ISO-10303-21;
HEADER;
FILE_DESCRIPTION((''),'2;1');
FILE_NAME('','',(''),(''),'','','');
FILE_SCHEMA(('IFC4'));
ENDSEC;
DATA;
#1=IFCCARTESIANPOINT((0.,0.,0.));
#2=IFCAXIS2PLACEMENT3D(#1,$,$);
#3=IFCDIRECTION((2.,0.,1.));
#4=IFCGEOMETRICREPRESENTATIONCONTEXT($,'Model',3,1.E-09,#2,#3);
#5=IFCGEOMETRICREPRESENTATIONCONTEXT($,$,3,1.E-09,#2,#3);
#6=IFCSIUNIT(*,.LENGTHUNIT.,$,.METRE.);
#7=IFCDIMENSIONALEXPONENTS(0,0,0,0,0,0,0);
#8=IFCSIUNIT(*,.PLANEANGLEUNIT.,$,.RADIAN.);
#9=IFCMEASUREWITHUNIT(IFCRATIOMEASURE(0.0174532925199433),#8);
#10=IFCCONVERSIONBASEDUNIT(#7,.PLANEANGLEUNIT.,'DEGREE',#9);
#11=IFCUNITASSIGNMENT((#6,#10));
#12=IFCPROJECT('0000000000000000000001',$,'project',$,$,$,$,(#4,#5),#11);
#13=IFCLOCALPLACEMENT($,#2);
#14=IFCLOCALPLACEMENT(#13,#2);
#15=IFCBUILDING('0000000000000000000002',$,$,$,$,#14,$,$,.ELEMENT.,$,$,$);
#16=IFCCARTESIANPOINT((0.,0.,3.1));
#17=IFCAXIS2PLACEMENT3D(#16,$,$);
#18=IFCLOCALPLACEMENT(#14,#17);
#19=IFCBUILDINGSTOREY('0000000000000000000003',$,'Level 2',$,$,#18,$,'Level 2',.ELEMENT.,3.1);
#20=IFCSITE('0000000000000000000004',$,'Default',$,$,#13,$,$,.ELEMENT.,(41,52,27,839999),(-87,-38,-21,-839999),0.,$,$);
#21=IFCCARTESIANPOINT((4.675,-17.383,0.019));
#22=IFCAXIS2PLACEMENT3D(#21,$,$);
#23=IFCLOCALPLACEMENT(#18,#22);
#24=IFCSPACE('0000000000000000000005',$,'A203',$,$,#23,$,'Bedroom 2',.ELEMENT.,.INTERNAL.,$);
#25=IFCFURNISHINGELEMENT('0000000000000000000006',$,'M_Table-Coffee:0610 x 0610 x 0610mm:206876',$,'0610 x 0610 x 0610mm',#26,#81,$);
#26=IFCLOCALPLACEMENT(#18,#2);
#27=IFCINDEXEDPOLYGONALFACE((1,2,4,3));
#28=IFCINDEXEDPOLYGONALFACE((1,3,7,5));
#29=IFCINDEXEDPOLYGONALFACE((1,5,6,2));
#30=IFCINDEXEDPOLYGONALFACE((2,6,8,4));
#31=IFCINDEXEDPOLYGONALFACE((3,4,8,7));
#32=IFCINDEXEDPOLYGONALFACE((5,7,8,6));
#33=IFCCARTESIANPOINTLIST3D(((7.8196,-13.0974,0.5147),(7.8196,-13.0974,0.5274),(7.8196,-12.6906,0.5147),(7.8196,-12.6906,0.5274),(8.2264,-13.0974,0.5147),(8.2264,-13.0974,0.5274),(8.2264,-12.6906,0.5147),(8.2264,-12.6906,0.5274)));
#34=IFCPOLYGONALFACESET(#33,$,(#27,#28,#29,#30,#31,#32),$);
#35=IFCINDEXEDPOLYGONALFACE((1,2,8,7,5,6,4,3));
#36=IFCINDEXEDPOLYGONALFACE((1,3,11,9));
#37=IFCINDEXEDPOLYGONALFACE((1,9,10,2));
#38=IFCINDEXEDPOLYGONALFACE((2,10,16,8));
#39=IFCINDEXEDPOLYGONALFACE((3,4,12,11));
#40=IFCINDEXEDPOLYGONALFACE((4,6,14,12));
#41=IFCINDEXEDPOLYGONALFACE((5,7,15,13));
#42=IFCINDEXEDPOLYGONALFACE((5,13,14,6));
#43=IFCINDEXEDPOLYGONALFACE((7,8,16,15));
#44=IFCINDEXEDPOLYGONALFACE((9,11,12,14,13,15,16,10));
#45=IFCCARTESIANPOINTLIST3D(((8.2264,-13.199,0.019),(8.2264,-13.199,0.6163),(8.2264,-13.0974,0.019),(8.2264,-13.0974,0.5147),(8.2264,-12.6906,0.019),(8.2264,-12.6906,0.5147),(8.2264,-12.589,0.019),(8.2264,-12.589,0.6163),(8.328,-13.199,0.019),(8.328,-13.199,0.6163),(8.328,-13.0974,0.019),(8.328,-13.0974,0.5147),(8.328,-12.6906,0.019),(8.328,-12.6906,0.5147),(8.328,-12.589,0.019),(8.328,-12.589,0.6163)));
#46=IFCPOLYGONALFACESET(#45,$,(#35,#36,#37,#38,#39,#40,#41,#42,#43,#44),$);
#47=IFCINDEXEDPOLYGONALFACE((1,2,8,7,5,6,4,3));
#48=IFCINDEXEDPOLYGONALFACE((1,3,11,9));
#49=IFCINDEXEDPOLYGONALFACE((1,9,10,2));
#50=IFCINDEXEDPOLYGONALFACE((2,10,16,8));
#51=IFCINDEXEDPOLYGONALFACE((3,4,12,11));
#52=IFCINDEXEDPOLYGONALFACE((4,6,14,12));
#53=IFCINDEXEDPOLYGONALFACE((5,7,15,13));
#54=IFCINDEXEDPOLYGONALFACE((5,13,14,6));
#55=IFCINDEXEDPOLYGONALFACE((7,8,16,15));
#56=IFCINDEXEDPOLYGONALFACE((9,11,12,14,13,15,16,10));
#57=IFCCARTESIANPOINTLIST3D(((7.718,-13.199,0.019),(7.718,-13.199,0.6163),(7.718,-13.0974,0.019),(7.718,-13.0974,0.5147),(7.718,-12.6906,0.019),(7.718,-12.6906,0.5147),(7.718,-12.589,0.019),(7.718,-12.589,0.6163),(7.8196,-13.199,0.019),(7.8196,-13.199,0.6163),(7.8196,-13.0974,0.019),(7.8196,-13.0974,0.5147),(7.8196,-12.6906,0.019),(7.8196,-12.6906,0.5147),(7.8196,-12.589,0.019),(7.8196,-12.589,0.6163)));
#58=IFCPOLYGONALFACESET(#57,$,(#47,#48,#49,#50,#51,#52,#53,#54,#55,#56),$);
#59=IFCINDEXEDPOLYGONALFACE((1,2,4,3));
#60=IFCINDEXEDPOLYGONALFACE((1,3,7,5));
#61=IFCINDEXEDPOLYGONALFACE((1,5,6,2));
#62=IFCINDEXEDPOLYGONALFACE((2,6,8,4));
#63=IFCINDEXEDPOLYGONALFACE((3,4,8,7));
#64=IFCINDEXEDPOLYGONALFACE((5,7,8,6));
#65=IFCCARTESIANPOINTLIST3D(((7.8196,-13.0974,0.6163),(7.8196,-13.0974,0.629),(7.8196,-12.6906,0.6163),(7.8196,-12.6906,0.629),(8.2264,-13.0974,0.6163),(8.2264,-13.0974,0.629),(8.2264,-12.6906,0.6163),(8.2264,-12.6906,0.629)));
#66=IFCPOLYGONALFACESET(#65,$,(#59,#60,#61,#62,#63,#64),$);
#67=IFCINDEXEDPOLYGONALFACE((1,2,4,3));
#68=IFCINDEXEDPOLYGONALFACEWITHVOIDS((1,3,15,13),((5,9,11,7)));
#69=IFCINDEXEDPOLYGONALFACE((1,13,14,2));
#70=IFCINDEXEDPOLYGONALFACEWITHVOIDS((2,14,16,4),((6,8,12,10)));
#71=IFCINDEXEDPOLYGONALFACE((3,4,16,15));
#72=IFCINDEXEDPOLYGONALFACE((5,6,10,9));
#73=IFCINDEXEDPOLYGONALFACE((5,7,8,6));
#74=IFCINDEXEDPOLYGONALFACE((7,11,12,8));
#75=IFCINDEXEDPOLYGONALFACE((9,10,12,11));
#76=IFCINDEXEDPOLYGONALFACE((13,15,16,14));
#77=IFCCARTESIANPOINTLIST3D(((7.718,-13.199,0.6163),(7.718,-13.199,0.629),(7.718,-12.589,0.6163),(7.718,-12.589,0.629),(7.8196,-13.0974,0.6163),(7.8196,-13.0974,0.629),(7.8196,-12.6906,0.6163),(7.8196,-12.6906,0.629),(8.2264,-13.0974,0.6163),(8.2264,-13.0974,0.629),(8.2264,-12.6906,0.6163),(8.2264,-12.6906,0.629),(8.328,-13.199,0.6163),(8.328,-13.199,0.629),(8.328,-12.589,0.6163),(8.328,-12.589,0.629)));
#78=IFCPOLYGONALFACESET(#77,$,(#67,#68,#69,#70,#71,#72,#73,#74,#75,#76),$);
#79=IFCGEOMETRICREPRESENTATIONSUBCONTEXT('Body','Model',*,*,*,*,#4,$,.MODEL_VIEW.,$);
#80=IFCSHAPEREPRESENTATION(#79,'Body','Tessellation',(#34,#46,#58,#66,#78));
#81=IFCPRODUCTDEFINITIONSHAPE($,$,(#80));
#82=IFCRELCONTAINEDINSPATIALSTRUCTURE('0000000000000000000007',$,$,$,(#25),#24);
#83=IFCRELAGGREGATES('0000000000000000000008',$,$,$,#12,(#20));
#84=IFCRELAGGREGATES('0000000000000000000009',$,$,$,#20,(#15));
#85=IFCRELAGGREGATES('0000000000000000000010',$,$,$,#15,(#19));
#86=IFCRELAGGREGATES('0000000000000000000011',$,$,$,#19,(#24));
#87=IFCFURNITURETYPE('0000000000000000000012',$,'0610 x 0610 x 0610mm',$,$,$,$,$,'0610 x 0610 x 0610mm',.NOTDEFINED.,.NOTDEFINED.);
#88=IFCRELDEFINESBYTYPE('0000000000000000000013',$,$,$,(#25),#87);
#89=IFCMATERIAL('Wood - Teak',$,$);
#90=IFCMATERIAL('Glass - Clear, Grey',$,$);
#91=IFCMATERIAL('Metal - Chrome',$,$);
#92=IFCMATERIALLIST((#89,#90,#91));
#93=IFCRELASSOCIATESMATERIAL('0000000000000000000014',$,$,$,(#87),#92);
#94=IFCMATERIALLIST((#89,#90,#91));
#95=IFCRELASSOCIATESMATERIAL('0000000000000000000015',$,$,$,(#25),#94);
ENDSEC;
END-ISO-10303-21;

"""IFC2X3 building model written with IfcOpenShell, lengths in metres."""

from ifc_helpers import new_model, entity, si_unit, converted_unit, direction, frame, origin, origin_2d_with_axis, place, context, subcontext, project, spatial, polyline, rectangle, outline, extrude, source, transform, mapped, material, material_list, type_object, type_shapes, element, save


model = new_model("IFC2X3")

# Units and contexts
model_context = context("Model", 3, precision=1e-09, world=origin(), true_north=direction((2.0, 0.0, 1.0)))
context_of_model = context(None, 3, precision=1e-09, world=origin(), true_north=direction((2.0, 0.0, 1.0)))
body_context = subcontext(model_context, "Body", "Model", "MODEL_VIEW")
ifc_project = project(units=[si_unit("LENGTHUNIT", "METRE"), converted_unit("PLANEANGLEUNIT", "DEGREE", entity("IfcRatioMeasure", 0.0174532925199433), si_unit("PLANEANGLEUNIT", "RADIAN"), dimensions=[0, 0, 0, 0, 0, 0, 0])], contexts=[model_context, context_of_model])

# Site, building, storey
site_placement = place(None, origin())
site = spatial("IfcSite", under=ifc_project, at=site_placement, Name="Default", CompositionType="ELEMENT", RefLatitude=(41, 52, 27, 839999), RefLongitude=(-87, -38, -21, -839999), RefElevation=0.0)
building_placement = place(site_placement, origin())
building = spatial("IfcBuilding", under=site, at=building_placement, CompositionType="ELEMENT")
storey_placement = place(building_placement, frame((0.0, 0.0, 3.1)))
storey = spatial("IfcBuildingStorey", under=building, at=storey_placement, Name="Level 2", LongName="Level 2", CompositionType="ELEMENT", Elevation=3.1)

# Shared definitions
space_1_placement = place(storey_placement, frame((4.675, -17.383, 0.019)))
space_1 = spatial("IfcSpace", under=storey, at=space_1_placement, Name="A203", LongName="Bedroom 2", CompositionType="ELEMENT", InteriorOrExteriorSpace="INTERNAL")

# Furnishing element
ifc_material_1 = material(Name="Wood - Teak")
ifc_material_2 = material(Name="Glass - Clear, Grey")
ifc_material_3 = material(Name="Metal - Chrome")
ifc_material_list_1 = material_list([ifc_material_1, ifc_material_2, ifc_material_3])
furniture_type_1 = type_object("IfcFurnitureType", Name="0610 x 0610 x 0610mm", ElementType="0610 x 0610 x 0610mm", AssemblyPlace="NOTDEFINED", material=ifc_material_list_1)
shared_shape_1 = source(origin(), body_context, "Body", "SweptSolid", [
    extrude(rectangle(XDim=0.4068, YDim=0.4068, at=origin_2d_with_axis()), frame((0.0183, 0.0952, 0.4957), z_axis=(0.0, 0.0, 1.0), x_axis=(-1.0, 0.0, 0.0)), (0.0, 0.0, 1.0), 0.0127),
    extrude(outline(polyline([(-0.2732, -0.305), (0.324, -0.305), (0.324, 0.305), (-0.2732, 0.305), (-0.2732, 0.2034), (0.2225, 0.2034), (0.2225, -0.2034), (-0.2732, -0.2034), (-0.2732, -0.305)])), frame((0.2217, 0.0952, 0.2732), z_axis=(1.0, 0.0, 0.0), x_axis=(0.0, 0.0, 1.0)), (0.0, 0.0, 1.0), 0.1016),
    extrude(outline(polyline([(-0.305, -0.3241), (0.305, -0.3241), (0.305, 0.2733), (0.2034, 0.2733), (0.2034, -0.2224), (-0.2034, -0.2224), (-0.2034, 0.2733), (-0.305, 0.2733), (-0.305, -0.3241)])), frame((-0.2867, 0.0952, 0.2733), z_axis=(1.0, 0.0, 0.0), x_axis=(0.0, -1.0, 0.0)), (0.0, 0.0, 1.0), 0.1016),
    extrude(rectangle(XDim=0.4068, YDim=0.4068, at=origin_2d_with_axis()), frame((0.0183, 0.0952, 0.5973), z_axis=(0.0, 0.0, 1.0), x_axis=(-1.0, 0.0, 0.0)), (0.0, 0.0, 1.0), 0.0127),
    extrude(outline(polyline([(-0.305, -0.305), (0.305, -0.305), (0.305, 0.305), (-0.305, 0.305), (-0.305, -0.305)]), holes=[polyline([(-0.2034, -0.2034), (-0.2034, 0.2034), (0.2034, 0.2034), (0.2034, -0.2034), (-0.2034, -0.2034)])]), frame((0.0183, 0.0952, 0.5973), z_axis=(0.0, 0.0, 1.0), x_axis=(-1.0, 0.0, 0.0)), (0.0, 0.0, 1.0), 0.0127),
])
type_shapes(furniture_type_1, [shared_shape_1])
ifc_material_list_2 = material_list([ifc_material_1, ifc_material_2, ifc_material_3])
furnishing_1_placement = place(space_1_placement, frame((3.3297, 4.3938, 0.0)))
element("IfcFurnishingElement", 1, at=furnishing_1_placement, inside=space_1, type_object=furniture_type_1, material=ifc_material_list_2, Name="M_Table-Coffee:0610 x 0610 x 0610mm:206876", ObjectType="0610 x 0610 x 0610mm", context=body_context, shape_type="MappedRepresentation", body=[
    mapped(shared_shape_1, transform((0.0, 0.0, 0.0), scale=1.0)),
])

save(model, "model.ifc")
